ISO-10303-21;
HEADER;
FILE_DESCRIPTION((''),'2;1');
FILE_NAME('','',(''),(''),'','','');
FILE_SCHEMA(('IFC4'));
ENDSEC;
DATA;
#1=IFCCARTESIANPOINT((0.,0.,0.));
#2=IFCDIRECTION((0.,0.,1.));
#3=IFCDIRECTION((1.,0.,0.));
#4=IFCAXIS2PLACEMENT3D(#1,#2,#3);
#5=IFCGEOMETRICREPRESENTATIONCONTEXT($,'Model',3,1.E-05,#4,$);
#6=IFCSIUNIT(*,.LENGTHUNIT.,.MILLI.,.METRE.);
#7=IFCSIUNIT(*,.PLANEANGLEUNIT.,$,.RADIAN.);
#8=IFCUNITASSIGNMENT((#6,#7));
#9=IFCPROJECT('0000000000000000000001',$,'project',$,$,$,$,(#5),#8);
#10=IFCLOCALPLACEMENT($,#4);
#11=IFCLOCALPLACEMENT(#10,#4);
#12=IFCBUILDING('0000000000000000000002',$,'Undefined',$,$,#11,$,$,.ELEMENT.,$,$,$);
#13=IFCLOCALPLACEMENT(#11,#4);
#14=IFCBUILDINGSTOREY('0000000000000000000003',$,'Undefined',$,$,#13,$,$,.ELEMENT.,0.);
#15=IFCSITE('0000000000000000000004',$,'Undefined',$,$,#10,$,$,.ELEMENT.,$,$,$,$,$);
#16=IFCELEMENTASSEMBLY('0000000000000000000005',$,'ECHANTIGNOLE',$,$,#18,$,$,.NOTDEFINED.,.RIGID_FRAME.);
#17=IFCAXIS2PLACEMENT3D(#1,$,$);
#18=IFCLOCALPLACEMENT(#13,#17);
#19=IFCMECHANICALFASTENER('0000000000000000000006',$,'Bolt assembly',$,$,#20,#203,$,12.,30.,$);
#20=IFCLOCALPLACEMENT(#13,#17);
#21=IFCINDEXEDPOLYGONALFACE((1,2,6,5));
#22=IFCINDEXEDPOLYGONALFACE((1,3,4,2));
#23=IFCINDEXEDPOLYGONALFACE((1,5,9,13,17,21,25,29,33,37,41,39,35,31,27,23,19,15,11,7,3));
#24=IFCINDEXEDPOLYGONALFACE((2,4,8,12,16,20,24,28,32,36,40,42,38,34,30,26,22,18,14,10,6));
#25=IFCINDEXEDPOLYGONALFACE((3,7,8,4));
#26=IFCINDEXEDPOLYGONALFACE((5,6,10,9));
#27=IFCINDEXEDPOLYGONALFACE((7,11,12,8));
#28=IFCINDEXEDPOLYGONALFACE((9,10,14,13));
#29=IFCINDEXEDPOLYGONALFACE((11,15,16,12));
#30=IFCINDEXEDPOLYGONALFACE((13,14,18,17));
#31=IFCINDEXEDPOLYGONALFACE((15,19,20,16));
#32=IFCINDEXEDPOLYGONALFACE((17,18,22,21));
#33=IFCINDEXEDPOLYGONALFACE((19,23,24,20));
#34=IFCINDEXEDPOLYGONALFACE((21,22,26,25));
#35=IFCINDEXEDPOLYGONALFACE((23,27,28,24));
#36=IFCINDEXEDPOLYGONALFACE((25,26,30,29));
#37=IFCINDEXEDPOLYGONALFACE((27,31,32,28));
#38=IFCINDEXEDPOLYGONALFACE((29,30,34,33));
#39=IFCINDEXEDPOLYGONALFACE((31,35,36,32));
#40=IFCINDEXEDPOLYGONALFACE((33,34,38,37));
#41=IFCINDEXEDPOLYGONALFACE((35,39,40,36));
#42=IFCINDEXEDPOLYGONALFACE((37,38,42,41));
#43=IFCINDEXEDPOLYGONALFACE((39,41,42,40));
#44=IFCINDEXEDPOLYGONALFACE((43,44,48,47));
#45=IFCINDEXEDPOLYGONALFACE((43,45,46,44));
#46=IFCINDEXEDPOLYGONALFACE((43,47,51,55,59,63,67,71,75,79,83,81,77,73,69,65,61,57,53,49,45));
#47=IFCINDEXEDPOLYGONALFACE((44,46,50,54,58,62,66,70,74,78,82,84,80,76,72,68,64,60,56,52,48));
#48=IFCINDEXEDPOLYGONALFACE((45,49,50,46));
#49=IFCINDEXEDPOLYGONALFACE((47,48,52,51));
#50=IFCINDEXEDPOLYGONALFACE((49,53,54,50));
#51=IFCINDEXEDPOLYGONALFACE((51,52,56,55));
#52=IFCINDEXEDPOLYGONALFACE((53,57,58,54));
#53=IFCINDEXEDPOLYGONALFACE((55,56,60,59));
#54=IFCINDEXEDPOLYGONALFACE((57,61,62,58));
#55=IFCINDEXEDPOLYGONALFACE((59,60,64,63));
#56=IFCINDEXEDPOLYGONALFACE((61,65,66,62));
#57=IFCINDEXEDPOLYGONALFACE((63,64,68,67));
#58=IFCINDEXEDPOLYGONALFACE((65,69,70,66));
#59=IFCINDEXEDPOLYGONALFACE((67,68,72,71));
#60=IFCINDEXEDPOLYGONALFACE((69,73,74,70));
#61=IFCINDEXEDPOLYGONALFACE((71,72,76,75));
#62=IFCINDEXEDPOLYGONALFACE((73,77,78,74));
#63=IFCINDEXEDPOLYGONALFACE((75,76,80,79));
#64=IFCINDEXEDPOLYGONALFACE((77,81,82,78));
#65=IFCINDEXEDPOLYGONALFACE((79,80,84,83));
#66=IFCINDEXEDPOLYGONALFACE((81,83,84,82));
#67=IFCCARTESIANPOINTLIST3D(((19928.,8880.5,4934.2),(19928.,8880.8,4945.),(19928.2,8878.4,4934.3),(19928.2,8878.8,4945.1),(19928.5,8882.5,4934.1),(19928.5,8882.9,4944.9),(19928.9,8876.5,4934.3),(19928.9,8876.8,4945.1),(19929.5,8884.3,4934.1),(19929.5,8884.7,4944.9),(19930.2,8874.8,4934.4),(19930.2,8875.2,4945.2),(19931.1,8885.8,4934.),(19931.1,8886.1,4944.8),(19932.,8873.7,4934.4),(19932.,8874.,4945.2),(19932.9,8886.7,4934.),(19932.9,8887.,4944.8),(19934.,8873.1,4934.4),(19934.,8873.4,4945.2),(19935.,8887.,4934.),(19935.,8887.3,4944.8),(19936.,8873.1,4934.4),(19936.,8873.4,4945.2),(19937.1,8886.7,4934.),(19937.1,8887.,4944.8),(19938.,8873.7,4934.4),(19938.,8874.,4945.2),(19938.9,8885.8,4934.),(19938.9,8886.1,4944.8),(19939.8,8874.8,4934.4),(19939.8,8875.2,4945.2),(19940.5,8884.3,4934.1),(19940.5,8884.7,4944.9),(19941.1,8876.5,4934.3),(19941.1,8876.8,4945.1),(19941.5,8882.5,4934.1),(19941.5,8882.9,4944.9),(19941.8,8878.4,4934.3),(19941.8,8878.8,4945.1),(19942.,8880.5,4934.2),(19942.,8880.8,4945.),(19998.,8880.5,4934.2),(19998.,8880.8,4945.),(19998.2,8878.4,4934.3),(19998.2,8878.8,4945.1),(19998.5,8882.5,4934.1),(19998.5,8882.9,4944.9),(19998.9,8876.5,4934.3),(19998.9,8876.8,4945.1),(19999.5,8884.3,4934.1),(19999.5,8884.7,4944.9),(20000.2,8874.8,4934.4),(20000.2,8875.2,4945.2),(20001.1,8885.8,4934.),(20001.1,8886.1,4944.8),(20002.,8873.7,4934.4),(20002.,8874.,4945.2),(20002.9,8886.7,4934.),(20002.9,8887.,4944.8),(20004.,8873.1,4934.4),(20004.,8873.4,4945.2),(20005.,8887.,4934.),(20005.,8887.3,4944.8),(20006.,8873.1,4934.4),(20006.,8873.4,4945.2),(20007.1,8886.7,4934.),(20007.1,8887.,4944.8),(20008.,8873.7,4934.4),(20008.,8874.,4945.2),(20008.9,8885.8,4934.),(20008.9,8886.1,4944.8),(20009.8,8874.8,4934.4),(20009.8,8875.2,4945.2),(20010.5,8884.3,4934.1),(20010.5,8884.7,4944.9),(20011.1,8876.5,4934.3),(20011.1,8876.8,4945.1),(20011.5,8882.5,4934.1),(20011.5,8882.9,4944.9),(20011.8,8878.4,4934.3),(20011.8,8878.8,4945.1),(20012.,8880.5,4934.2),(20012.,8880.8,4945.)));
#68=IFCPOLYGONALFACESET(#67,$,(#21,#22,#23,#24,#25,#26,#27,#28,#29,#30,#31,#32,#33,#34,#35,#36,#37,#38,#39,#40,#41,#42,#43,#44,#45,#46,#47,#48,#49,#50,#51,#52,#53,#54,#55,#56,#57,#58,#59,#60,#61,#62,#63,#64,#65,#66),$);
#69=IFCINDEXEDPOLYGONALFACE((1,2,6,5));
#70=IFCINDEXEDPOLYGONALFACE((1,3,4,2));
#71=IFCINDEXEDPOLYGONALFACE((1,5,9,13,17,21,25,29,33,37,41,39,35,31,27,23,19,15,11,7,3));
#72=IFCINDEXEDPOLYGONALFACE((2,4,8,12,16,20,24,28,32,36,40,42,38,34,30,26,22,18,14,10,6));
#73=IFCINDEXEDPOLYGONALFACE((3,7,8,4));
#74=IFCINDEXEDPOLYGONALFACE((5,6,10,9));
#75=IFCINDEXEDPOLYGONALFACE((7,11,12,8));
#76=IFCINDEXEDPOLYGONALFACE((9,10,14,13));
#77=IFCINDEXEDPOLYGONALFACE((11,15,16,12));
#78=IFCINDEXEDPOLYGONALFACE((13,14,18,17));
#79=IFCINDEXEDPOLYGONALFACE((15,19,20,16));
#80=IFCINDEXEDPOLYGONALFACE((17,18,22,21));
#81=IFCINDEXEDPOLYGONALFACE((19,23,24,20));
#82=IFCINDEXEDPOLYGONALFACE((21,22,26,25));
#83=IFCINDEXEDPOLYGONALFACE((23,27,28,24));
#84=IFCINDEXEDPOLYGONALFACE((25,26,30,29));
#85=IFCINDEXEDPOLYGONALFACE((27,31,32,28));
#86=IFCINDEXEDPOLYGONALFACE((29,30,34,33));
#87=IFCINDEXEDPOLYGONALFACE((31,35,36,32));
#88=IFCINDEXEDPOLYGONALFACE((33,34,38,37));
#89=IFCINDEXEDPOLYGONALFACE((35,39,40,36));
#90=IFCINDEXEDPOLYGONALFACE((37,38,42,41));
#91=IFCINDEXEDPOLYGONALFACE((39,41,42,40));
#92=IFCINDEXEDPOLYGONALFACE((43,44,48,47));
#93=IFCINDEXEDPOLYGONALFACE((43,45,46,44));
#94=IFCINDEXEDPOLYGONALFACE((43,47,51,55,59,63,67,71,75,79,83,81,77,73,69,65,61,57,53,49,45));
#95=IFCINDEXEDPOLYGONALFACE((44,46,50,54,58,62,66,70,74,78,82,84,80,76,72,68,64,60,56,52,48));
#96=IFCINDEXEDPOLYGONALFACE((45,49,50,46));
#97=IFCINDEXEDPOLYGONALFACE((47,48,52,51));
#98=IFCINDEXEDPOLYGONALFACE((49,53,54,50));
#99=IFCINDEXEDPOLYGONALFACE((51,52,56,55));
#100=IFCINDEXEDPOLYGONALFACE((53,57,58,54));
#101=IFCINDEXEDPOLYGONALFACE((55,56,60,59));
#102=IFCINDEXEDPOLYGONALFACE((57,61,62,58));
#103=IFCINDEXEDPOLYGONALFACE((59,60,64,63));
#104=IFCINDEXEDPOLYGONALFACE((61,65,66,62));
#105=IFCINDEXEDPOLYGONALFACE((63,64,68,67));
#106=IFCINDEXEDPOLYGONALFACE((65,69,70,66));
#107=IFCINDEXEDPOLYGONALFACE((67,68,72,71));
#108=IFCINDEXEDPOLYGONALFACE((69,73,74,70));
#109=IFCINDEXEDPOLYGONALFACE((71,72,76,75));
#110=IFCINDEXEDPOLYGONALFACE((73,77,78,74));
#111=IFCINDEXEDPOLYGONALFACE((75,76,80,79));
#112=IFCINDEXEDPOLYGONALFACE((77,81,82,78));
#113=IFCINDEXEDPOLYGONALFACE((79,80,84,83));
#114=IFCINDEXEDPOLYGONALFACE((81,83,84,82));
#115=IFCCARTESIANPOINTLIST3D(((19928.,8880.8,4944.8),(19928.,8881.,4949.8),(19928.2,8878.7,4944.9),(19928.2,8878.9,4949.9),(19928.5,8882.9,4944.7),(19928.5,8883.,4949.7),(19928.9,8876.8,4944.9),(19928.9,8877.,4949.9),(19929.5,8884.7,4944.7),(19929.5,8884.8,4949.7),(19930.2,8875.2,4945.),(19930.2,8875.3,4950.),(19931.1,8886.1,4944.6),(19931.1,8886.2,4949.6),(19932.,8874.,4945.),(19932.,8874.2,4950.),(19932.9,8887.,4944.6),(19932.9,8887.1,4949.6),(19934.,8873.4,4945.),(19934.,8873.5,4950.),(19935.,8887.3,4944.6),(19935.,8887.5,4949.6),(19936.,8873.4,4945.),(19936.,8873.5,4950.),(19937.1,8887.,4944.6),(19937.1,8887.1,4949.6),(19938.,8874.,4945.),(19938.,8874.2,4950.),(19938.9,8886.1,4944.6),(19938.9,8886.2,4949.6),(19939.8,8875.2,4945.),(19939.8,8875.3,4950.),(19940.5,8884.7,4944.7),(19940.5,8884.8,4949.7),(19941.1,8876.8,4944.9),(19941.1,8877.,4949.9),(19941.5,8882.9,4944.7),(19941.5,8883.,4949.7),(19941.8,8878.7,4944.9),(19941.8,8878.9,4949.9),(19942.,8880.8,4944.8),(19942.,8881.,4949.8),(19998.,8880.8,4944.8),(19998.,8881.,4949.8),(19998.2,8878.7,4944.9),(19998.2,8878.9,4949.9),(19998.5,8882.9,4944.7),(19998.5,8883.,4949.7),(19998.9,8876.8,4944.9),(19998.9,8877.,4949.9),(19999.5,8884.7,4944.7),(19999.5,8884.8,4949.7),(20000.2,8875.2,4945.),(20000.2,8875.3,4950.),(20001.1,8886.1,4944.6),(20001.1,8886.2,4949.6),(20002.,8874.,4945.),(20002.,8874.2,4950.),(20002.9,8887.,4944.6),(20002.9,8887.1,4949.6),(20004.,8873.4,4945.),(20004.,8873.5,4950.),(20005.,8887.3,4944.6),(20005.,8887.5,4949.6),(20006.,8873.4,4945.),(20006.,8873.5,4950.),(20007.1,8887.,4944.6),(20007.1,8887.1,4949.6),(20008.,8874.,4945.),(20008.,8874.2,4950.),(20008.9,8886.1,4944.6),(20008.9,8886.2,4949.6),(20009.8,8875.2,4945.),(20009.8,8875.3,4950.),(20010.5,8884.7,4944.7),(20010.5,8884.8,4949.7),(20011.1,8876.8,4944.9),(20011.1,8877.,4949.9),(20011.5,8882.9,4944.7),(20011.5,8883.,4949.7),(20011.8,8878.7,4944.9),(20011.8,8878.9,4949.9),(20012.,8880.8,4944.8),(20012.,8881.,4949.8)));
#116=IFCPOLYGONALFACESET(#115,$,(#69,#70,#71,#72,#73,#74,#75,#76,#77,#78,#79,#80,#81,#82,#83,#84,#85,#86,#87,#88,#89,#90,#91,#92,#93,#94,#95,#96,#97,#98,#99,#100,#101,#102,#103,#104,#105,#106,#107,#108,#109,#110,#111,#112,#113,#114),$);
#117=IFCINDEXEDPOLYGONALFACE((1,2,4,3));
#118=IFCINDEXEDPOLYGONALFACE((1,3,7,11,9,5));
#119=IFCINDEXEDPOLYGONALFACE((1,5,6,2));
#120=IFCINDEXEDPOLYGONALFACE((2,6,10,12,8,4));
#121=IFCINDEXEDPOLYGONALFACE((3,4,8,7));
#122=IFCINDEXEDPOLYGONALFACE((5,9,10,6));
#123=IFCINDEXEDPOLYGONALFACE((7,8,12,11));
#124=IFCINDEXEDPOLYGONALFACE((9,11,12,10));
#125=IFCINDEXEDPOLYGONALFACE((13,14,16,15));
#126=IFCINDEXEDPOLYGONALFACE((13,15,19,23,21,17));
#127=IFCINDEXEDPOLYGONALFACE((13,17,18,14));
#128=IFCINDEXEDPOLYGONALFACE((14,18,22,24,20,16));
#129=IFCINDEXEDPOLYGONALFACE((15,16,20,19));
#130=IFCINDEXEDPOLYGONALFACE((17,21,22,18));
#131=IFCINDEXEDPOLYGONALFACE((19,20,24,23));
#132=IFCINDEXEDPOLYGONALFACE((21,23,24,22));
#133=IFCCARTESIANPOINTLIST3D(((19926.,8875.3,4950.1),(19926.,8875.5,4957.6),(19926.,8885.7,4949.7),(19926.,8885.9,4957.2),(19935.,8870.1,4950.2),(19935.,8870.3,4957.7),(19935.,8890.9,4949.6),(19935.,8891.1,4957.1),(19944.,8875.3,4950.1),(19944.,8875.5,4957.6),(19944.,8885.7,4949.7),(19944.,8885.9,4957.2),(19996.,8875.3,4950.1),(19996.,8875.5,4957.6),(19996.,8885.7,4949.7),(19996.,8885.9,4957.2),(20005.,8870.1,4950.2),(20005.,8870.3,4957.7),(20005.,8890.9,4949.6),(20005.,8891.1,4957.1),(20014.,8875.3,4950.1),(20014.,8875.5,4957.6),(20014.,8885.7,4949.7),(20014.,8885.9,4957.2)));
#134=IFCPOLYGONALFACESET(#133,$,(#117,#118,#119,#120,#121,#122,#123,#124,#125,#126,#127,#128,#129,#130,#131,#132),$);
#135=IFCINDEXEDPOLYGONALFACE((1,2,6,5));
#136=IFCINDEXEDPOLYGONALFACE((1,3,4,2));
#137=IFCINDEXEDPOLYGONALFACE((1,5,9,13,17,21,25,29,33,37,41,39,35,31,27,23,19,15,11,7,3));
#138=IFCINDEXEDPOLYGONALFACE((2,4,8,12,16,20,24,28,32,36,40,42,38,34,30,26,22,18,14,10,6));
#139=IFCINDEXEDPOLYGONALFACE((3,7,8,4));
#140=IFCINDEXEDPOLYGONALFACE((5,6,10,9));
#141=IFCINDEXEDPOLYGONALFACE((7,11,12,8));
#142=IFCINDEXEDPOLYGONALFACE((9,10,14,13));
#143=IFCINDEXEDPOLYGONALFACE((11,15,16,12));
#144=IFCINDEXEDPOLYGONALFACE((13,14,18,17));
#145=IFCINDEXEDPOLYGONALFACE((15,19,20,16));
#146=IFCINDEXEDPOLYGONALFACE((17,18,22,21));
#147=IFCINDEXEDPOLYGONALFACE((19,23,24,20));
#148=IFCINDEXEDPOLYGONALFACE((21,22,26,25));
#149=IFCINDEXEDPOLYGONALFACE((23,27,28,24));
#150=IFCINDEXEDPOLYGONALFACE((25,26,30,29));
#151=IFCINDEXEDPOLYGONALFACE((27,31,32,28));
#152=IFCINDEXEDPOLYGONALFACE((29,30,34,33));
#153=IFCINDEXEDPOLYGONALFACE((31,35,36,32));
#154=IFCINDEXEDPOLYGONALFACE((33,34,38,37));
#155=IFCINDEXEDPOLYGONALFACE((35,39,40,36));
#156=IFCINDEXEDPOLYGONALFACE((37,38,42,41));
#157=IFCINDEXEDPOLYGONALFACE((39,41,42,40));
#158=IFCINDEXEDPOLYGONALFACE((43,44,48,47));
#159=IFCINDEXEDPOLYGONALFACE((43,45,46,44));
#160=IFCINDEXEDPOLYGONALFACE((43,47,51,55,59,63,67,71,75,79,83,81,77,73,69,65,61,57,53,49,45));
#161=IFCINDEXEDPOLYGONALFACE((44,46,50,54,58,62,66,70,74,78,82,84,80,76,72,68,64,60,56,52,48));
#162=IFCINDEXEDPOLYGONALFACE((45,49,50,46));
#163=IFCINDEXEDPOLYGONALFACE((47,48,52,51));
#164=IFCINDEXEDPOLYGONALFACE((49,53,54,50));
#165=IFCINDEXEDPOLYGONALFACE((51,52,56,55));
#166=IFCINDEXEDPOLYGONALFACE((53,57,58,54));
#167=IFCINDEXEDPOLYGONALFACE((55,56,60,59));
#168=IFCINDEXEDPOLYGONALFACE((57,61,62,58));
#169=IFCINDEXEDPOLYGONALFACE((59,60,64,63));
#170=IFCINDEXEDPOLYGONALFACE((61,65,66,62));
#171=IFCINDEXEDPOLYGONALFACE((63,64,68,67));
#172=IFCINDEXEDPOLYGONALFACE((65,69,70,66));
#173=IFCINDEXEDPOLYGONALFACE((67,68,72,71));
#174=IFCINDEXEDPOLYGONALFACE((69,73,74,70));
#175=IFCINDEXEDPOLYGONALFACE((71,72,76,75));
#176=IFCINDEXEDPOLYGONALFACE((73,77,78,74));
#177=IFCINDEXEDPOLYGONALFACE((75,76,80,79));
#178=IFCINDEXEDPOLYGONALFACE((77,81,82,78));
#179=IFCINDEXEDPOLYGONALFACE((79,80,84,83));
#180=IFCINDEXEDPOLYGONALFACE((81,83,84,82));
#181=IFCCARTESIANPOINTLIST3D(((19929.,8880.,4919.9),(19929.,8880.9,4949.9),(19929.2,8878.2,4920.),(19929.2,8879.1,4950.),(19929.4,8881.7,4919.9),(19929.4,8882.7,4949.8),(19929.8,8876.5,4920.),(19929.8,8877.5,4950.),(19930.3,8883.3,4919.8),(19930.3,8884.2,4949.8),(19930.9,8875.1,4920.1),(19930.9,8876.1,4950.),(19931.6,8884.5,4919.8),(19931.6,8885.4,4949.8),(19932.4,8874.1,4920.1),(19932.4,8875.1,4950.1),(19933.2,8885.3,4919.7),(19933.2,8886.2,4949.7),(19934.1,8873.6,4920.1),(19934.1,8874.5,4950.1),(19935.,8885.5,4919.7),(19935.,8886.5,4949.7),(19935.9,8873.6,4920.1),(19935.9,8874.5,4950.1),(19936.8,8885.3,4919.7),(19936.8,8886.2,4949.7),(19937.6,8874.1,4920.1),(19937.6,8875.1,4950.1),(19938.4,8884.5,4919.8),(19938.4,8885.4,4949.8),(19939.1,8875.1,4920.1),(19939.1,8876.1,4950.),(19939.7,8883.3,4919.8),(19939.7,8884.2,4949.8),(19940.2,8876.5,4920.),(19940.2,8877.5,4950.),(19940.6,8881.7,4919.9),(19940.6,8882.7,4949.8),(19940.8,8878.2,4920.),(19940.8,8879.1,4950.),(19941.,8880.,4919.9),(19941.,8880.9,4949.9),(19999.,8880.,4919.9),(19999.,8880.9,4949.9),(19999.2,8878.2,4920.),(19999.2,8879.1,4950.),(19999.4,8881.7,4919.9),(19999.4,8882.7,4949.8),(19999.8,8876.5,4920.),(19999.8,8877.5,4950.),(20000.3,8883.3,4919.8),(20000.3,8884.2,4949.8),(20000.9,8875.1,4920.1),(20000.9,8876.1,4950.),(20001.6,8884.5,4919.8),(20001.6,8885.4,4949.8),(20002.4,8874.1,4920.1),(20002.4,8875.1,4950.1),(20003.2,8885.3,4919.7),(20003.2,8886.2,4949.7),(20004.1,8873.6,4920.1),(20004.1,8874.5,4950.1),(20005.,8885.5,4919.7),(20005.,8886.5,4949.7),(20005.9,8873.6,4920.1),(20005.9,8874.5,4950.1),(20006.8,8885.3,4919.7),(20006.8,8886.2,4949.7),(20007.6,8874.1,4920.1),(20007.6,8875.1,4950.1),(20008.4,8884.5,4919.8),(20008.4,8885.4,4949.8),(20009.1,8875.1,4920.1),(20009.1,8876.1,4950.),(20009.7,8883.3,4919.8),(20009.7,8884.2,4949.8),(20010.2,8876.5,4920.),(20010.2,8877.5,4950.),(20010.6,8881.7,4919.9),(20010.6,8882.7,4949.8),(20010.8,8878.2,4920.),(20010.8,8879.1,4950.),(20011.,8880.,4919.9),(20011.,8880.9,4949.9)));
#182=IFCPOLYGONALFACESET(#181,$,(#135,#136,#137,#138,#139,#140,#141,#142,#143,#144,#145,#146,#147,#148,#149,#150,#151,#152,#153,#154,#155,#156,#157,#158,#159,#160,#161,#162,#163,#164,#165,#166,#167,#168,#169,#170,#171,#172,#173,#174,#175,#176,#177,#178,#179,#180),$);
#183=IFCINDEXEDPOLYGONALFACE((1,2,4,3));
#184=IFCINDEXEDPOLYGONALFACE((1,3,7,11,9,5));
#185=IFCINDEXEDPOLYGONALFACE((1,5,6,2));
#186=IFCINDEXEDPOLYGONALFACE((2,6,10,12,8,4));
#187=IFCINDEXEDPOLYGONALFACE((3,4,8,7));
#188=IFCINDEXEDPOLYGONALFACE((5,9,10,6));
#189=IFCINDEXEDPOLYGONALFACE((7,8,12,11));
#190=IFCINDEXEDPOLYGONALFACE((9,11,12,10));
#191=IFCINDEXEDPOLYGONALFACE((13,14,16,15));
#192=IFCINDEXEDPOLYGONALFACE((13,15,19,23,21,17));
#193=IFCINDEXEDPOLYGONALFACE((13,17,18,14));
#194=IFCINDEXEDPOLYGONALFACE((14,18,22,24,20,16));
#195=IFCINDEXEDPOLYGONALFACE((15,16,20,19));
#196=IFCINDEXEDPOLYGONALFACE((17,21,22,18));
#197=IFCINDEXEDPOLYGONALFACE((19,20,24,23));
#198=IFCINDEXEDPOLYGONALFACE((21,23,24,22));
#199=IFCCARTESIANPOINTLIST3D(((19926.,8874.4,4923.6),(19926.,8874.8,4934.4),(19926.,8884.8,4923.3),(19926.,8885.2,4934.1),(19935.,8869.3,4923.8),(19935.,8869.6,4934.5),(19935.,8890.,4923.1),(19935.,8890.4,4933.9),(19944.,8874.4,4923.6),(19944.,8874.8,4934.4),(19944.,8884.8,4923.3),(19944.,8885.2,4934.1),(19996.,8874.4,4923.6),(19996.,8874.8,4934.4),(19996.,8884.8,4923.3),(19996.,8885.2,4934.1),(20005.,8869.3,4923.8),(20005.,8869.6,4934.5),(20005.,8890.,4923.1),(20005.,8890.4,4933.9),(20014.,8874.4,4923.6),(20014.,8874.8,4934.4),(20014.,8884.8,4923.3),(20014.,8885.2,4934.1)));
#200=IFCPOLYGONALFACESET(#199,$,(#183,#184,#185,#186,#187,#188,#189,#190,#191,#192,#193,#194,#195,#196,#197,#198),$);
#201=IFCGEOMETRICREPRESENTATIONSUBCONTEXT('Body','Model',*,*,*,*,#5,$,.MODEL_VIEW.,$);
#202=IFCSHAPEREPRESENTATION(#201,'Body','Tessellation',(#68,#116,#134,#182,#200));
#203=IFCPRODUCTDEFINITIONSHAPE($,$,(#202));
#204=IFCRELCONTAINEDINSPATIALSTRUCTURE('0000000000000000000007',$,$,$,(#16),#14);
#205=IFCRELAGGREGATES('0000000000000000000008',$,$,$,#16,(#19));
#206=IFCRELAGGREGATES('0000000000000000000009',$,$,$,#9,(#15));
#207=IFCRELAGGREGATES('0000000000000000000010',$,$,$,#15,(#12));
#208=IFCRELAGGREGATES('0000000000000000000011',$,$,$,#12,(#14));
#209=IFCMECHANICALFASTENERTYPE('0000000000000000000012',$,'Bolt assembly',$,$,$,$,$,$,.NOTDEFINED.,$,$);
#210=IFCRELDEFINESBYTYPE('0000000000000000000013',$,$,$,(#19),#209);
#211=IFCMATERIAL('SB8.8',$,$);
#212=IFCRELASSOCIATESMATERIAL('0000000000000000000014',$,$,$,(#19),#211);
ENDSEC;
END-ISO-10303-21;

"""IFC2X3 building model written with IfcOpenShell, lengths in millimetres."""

from ifc_helpers import new_model, si_unit, frame, origin_with_axes, origin_2d_with_axis, place, context, subcontext, project, spatial, polyline, circle, outline, extrude, source, transform, mapped, material, type_object, element, aggregate, save


model = new_model("IFC2X3")

# Units and contexts
model_context = context("Model", 3, precision=1e-05, world=origin_with_axes())
body_context = subcontext(model_context, "Body", "Model", "MODEL_VIEW")
ifc_project = project(units=[si_unit("LENGTHUNIT", "METRE", prefix="MILLI"), si_unit("PLANEANGLEUNIT", "RADIAN")], contexts=[model_context])

# Site, building, storey
site_placement = place(None, origin_with_axes())
site = spatial("IfcSite", under=ifc_project, at=site_placement, Name="Undefined", CompositionType="ELEMENT")
building_placement = place(site_placement, origin_with_axes())
building = spatial("IfcBuilding", under=site, at=building_placement, Name="Undefined", CompositionType="ELEMENT")
storey_placement = place(building_placement, origin_with_axes())
storey = spatial("IfcBuildingStorey", under=building, at=storey_placement, Name="Undefined", CompositionType="ELEMENT", Elevation=0.0)

# Shared definitions
ifc_material_1 = material(Name="SB8.8")
mechanical_fastener_type = type_object("IfcMechanicalFastenerType", Name="Bolt assembly")

# Element assembly, mechanical fastener
assembly_1_placement = place(storey_placement, origin_with_axes())
assembly_1 = element("IfcElementAssembly", 1, at=assembly_1_placement, inside=storey, Name="ECHANTIGNOLE", AssemblyPlace="NOTDEFINED", PredefinedType="RIGID_FRAME")
shared_shape_1 = source(origin_with_axes(), body_context, "Body", "SweptSolid", [
    extrude(circle(Radius=7.0, at=origin_2d_with_axis()), frame((0.0, -0.1, 0.0), z_axis=(0.0, 1.0, 0.0), x_axis=(1.0, 0.0, 0.0)), (0.0, 0.0, 1.0), 10.8),
    extrude(circle(Radius=7.0, at=origin_2d_with_axis()), frame((0.0, -4.9, 0.0), z_axis=(0.0, 1.0, 0.0), x_axis=(1.0, 0.0, 0.0)), (0.0, 0.0, 1.0), 5.0),
    extrude(outline(polyline([(10.4, 0.0), (5.2, 9.0), (-5.2, 9.0), (-10.4, 0.0), (-5.2, -9.0), (5.2, -9.0), (10.4, 0.0)])), frame((0.0, -12.5, 0.0), z_axis=(0.0, 1.0, 0.0), x_axis=(1.0, 0.0, 0.0)), (0.0, 0.0, 1.0), 7.5),
    extrude(circle(Radius=6.0, at=origin_2d_with_axis()), frame((0.0, -5.0, 0.0), z_axis=(0.0, 1.0, 0.0), x_axis=(1.0, 0.0, 0.0)), (0.0, 0.0, 1.0), 30.0),
    extrude(outline(polyline([(10.4, 0.0), (5.2, 9.0), (-5.2, 9.0), (-10.4, 0.0), (-5.2, -9.0), (5.2, -9.0), (10.4, 0.0)])), frame((0.0, 10.7, 0.0), z_axis=(0.0, 1.0, 0.0), x_axis=(1.0, 0.0, 0.0)), (0.0, 0.0, 1.0), 10.8),
])
mechanical_fastener_1_placement = place(assembly_1_placement, frame((19970.0, 8880.3, 4944.9), z_axis=(-1.0, 0.0, 0.0), x_axis=(0.0, 0.99952, -0.030986)))
mechanical_fastener_1 = element("IfcMechanicalFastener", 2, at=mechanical_fastener_1_placement, type_object=mechanical_fastener_type, material=ifc_material_1, Name="Bolt assembly", NominalDiameter=12.0, NominalLength=30.0, context=body_context, shape_type="MappedRepresentation", body=[
    mapped(shared_shape_1, transform((0.0, 0.0, 35.0))),
    mapped(shared_shape_1, transform((0.0, 0.0, -35.0))),
])
aggregate(assembly_1, [mechanical_fastener_1])

save(model, "model.ifc")
